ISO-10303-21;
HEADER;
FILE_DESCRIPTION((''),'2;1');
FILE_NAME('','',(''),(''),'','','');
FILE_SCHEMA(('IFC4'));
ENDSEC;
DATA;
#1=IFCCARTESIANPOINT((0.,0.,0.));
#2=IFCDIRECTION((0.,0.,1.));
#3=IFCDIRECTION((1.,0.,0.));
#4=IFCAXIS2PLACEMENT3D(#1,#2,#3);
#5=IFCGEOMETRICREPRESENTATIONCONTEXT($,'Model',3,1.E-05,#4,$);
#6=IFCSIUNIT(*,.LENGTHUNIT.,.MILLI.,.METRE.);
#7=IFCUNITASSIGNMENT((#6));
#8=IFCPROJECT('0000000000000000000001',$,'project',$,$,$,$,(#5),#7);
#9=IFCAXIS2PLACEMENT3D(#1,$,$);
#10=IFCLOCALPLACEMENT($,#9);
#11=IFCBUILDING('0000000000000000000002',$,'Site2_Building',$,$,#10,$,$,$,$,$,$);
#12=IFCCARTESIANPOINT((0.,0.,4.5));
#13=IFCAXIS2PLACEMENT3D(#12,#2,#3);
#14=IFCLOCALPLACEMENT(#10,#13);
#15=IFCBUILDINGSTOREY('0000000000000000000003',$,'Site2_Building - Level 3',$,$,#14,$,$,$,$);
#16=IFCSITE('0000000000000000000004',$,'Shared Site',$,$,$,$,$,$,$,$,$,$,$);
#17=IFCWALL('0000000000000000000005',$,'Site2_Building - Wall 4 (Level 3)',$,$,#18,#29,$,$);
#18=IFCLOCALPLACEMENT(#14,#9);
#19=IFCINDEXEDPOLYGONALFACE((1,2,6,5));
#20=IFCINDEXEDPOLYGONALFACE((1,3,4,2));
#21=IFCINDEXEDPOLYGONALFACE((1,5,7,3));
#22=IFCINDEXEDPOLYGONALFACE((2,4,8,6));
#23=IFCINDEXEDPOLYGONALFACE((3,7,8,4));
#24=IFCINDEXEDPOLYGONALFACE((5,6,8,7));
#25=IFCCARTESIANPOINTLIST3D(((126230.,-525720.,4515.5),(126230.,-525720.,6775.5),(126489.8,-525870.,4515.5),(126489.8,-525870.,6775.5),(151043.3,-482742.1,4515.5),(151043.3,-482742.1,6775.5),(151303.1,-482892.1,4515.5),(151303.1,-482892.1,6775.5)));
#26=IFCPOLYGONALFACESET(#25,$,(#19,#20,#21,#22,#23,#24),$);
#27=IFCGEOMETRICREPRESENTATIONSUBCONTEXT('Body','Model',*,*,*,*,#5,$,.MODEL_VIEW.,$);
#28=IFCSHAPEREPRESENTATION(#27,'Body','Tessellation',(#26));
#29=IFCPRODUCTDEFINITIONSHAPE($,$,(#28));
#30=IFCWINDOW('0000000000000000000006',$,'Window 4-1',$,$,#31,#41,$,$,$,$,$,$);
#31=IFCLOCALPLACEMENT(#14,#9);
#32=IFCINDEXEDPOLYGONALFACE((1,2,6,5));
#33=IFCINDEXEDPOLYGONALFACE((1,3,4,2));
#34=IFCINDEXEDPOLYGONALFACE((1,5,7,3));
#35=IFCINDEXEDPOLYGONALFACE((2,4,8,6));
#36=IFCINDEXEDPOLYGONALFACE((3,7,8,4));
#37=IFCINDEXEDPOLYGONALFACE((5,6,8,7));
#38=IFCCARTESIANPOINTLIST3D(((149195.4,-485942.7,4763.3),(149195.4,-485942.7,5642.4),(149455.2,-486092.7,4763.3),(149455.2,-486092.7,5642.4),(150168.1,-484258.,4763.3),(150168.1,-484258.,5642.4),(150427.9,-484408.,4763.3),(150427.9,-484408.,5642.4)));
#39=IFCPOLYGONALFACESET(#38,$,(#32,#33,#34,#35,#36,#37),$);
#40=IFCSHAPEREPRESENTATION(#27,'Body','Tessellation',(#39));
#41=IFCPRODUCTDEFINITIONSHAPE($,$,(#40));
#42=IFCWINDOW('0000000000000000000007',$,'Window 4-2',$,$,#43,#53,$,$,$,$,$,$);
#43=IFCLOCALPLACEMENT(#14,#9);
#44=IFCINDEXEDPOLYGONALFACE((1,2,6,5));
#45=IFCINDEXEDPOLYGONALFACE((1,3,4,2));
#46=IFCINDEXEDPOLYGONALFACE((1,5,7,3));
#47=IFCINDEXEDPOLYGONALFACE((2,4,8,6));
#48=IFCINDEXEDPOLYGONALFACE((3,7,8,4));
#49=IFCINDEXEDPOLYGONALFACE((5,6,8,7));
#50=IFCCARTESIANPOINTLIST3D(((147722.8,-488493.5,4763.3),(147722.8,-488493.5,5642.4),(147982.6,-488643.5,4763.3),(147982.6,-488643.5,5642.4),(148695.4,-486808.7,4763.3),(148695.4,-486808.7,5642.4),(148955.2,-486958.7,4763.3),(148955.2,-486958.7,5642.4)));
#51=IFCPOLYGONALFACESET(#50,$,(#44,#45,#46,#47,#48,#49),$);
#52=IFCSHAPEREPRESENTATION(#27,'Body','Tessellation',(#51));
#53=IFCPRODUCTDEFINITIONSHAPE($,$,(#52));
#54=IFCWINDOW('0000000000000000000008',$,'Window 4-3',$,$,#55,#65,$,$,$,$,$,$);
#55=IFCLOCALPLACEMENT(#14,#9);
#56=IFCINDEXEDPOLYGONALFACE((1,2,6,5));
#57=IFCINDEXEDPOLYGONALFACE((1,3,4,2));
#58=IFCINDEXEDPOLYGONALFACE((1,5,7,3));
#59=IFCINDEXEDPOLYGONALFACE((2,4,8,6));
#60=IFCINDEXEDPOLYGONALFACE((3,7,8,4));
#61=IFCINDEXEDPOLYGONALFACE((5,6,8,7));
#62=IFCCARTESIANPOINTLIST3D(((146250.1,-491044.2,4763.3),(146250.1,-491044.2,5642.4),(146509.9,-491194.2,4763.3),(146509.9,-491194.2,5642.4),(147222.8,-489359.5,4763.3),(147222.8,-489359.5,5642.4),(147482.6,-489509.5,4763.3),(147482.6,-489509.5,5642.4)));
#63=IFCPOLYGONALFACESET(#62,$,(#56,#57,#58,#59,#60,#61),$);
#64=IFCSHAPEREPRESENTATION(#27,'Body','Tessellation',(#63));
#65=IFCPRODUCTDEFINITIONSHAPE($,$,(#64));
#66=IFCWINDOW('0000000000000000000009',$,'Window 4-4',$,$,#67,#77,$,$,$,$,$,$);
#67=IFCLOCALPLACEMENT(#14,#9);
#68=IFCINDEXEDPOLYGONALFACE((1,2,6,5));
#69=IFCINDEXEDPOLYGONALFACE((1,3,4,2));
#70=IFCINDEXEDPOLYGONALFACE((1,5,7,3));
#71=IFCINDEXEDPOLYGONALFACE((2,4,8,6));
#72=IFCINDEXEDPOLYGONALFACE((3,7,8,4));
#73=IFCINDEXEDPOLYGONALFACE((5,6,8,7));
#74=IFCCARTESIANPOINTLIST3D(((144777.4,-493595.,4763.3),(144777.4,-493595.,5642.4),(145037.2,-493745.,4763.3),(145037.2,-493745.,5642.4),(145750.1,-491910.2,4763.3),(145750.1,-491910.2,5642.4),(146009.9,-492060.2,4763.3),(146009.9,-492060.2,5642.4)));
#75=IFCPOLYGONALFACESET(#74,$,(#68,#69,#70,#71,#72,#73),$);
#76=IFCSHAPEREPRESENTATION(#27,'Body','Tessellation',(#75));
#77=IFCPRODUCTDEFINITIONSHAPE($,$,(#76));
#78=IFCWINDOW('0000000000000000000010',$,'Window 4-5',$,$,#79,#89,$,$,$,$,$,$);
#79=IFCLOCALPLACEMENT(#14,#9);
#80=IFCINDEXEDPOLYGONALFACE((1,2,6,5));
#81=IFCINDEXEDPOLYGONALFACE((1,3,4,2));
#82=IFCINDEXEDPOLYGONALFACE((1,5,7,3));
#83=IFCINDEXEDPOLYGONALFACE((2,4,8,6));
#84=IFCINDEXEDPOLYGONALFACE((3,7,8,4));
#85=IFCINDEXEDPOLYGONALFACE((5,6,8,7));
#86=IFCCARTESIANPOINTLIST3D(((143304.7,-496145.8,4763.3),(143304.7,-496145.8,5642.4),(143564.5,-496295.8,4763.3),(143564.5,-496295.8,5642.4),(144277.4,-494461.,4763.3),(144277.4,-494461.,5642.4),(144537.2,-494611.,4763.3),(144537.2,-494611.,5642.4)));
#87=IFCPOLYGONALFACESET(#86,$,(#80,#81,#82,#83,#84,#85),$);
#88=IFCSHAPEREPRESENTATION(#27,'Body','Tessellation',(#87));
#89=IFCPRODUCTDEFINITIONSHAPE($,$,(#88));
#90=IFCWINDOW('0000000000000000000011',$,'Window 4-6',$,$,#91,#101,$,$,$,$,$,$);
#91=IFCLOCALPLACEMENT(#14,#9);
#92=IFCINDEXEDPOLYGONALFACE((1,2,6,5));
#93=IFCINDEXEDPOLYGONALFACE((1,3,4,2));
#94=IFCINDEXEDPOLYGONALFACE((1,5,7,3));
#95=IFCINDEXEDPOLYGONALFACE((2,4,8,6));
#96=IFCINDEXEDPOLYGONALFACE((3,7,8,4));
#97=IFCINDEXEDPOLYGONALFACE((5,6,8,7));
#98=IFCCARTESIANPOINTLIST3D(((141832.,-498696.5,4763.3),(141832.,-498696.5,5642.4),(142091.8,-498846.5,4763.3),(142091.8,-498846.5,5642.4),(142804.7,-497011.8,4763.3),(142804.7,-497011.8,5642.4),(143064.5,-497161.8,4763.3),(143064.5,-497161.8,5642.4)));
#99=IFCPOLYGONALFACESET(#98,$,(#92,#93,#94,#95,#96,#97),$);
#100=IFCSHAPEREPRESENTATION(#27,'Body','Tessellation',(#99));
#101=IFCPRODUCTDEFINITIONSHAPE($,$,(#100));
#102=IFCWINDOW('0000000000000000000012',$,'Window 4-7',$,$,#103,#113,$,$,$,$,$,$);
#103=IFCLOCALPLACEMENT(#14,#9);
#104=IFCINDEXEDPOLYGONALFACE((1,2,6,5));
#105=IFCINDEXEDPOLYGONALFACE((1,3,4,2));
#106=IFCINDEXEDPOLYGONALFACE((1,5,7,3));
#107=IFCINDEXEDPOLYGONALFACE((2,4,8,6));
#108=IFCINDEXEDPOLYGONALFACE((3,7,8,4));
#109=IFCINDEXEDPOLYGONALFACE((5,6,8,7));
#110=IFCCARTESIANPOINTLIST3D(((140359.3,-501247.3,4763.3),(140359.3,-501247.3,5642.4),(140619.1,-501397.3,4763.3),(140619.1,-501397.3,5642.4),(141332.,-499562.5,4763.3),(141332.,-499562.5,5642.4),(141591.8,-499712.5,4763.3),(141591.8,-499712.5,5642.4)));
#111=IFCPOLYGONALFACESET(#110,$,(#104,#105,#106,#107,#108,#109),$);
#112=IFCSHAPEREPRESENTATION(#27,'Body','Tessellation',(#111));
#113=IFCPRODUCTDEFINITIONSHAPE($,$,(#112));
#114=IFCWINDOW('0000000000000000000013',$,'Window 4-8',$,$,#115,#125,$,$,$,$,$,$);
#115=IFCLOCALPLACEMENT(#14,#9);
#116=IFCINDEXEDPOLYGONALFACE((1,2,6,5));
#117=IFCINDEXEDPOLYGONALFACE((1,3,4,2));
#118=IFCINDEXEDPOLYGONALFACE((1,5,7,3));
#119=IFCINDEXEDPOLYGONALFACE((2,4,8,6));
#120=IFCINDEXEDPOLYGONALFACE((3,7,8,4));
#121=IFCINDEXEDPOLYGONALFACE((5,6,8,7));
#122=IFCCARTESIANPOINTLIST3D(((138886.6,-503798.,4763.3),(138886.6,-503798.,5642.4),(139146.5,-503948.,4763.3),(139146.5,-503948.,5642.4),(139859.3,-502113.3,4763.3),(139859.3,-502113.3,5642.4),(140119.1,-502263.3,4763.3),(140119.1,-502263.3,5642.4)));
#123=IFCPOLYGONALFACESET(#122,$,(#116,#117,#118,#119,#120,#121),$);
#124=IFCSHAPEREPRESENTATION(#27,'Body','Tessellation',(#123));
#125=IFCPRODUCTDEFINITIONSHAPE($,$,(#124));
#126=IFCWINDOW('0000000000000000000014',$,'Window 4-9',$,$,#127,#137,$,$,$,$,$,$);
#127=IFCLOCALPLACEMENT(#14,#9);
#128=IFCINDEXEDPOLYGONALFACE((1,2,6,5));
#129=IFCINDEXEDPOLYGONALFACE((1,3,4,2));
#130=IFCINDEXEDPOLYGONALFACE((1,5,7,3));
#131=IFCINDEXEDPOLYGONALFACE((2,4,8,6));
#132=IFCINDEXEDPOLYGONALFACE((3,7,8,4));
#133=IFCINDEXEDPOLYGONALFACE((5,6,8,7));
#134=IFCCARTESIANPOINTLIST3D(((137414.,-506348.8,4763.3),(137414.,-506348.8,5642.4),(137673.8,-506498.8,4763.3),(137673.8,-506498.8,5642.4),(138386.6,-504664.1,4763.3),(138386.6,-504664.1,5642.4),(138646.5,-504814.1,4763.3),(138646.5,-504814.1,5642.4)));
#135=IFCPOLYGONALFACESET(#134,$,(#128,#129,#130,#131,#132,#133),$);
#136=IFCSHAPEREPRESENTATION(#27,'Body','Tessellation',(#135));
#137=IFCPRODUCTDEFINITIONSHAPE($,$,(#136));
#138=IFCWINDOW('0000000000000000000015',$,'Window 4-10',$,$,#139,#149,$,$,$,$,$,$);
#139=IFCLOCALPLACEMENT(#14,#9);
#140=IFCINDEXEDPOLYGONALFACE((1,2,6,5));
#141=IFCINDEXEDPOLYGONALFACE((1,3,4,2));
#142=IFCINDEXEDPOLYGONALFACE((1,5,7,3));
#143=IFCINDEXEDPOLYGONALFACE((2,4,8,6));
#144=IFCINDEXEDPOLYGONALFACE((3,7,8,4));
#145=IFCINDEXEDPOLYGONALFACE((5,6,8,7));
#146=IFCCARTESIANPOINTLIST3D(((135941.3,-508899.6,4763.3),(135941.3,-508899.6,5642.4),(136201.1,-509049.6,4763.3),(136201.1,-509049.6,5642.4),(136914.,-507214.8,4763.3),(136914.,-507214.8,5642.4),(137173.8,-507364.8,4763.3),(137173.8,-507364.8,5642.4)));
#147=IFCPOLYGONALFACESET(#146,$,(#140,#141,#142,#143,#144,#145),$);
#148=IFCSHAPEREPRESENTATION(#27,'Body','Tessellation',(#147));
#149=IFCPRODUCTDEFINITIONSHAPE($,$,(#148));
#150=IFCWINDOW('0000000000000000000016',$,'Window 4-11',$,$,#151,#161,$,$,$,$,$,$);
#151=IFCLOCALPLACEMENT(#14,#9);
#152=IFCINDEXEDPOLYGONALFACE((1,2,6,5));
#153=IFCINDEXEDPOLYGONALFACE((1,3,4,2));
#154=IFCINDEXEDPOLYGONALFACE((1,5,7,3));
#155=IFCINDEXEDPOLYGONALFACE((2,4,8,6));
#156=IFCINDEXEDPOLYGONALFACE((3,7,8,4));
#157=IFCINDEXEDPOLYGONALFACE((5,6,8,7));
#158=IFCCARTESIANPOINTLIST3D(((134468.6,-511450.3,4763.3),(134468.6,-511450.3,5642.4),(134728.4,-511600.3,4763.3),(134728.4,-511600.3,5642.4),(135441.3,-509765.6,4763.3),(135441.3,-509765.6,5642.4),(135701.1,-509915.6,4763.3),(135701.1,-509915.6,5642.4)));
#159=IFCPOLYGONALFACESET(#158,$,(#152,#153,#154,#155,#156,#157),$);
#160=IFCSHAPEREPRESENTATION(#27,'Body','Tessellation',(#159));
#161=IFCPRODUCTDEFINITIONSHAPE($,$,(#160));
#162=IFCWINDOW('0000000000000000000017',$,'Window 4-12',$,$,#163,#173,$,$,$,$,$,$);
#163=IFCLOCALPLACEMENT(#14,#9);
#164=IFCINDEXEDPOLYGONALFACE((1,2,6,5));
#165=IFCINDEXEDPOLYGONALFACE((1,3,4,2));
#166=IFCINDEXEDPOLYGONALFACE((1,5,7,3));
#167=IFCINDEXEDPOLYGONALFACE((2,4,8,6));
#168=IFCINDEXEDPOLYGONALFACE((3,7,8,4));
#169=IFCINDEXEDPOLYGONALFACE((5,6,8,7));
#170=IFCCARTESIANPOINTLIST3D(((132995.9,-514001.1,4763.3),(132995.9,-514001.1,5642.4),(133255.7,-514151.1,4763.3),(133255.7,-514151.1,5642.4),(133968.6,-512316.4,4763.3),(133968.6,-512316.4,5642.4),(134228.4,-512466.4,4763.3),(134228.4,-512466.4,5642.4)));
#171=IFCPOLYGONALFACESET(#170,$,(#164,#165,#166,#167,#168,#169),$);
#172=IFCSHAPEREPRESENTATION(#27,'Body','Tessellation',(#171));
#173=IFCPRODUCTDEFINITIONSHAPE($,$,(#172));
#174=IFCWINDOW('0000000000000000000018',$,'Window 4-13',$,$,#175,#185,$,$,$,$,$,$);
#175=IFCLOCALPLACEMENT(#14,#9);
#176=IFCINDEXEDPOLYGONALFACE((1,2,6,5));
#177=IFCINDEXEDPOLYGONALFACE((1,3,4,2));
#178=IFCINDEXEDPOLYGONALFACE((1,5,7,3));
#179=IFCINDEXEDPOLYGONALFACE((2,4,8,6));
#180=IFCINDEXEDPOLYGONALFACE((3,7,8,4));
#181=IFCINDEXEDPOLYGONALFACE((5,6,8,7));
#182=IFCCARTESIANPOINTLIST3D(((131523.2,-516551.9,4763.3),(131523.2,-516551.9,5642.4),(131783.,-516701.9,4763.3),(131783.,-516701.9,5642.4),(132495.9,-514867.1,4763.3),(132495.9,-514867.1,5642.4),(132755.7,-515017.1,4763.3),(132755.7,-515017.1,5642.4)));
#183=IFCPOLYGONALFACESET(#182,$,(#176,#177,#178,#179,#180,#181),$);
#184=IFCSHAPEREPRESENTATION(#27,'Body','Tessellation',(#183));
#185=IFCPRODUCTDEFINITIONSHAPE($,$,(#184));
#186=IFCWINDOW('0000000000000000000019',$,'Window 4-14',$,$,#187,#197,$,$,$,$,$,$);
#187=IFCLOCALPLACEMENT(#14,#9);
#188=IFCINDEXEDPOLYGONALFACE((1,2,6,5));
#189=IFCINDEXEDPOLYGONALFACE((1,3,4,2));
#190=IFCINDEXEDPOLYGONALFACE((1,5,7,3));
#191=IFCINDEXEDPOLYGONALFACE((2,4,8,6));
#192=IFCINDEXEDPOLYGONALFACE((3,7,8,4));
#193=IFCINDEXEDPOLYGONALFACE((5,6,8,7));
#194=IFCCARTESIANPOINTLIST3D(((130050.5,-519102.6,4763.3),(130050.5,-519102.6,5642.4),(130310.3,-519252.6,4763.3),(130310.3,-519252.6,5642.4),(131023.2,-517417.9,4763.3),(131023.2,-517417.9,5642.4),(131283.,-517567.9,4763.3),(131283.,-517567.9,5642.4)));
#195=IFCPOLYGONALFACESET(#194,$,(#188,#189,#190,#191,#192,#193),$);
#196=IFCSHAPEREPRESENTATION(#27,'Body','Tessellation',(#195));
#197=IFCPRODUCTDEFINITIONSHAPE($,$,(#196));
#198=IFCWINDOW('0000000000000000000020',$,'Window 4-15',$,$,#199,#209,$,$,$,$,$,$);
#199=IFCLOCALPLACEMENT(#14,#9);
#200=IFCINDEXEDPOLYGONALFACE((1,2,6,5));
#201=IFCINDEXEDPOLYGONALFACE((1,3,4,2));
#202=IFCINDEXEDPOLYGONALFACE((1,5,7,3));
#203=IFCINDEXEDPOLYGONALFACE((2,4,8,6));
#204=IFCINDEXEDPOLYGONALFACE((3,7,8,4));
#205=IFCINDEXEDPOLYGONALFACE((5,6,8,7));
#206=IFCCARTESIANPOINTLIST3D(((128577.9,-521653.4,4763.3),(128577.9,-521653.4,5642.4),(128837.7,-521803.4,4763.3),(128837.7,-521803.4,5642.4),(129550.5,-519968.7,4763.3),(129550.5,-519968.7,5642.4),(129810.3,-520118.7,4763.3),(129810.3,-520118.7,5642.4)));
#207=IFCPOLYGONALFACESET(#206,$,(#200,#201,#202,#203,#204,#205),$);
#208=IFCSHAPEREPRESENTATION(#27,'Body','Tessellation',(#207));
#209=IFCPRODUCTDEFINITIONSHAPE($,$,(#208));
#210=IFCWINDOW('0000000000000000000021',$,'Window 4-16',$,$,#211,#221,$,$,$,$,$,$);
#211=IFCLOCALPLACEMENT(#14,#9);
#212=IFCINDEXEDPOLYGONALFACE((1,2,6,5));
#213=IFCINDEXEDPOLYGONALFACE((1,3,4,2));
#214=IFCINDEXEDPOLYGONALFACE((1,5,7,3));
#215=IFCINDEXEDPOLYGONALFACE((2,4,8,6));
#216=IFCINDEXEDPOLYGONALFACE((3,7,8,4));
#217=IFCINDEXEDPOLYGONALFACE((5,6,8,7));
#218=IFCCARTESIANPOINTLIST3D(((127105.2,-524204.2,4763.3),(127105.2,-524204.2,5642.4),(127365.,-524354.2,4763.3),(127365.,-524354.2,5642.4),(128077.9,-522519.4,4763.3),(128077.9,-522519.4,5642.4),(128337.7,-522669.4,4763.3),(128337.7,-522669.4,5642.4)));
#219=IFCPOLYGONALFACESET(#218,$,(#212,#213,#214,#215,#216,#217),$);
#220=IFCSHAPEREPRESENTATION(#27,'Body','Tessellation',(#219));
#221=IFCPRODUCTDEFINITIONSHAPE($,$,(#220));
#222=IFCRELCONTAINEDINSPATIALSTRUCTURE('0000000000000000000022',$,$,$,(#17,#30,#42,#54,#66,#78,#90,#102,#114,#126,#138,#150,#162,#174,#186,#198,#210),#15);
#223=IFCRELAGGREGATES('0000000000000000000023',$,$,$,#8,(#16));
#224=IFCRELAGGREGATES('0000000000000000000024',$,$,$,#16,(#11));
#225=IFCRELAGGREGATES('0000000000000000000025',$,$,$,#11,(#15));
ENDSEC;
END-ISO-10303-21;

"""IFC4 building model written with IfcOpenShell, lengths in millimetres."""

from ifc_helpers import new_model, si_unit, frame, origin, origin_with_axes, place, context, subcontext, project, spatial, indexed_curve, outline, extrude, element, save


model = new_model("IFC4")

# Units and contexts
model_context = context("Model", 3, precision=1e-05, world=origin_with_axes())
body_context = subcontext(model_context, "Body", "Model", "MODEL_VIEW")
ifc_project = project(units=[si_unit("LENGTHUNIT", "METRE", prefix="MILLI")], contexts=[model_context])

# Site, building, storey
site = spatial("IfcSite", under=ifc_project, Name="Shared Site")
building_placement = place(None, origin())
building = spatial("IfcBuilding", under=site, at=building_placement, Name="Site2_Building")
storey_placement = place(building_placement, frame((0.0, 0.0, 4.5), z_axis=(0.0, 0.0, 1.0), x_axis=(1.0, 0.0, 0.0)))
storey = spatial("IfcBuildingStorey", under=building, at=storey_placement, Name="Site2_Building - Level 3")

# Wall
wall_1_placement = place(storey_placement, frame((151043.3, -482742.1, 4515.5), z_axis=(0.0, 0.0, 1.0), x_axis=(-0.5, -0.866025, 0.0)))
element("IfcWall", 1, at=wall_1_placement, inside=storey, Name="Site2_Building - Wall 4 (Level 3)", context=body_context, shape_type="SweptSolid", body=[
    extrude(outline(indexed_curve([(0.0, 0.0), (0.0, 300.0), (49626.6, 300.0), (49626.6, 0.0), (0.0, 0.0)], self_intersect=False)), origin_with_axes(), (0.0, 0.0, 1.0), 2260.0),
])

# Windows
for number, where, z_axis, x_axis, name in (
    (2, (150168.1, -484258.0, 4763.3), (0.0, 0.0, 1.0), (-0.5, -0.866025, 0.0), "Window 4-1"),
    (3, (148695.4, -486808.7, 4763.3), (0.0, 0.0, 1.0), (-0.5, -0.866025, 0.0), "Window 4-2"),
    (4, (147222.8, -489359.5, 4763.3), (0.0, 0.0, 1.0), (-0.5, -0.866025, 0.0), "Window 4-3"),
    (5, (145750.1, -491910.2, 4763.3), (0.0, 0.0, 1.0), (-0.5, -0.866025, 0.0), "Window 4-4"),
    (6, (144277.4, -494461.0, 4763.3), (0.0, 0.0, 1.0), (-0.5, -0.866025, 0.0), "Window 4-5"),
    (7, (142804.7, -497011.8, 4763.3), (0.0, 0.0, 1.0), (-0.5, -0.866025, 0.0), "Window 4-6"),
    (8, (141332.0, -499562.5, 4763.3), (0.0, 0.0, 1.0), (-0.5, -0.866025, 0.0), "Window 4-7"),
    (9, (139859.3, -502113.3, 4763.3), (0.0, 0.0, 1.0), (-0.5, -0.866025, 0.0), "Window 4-8"),
    (10, (138386.6, -504664.1, 4763.3), (0.0, 0.0, 1.0), (-0.5, -0.866025, 0.0), "Window 4-9"),
    (11, (136914.0, -507214.8, 4763.3), (0.0, 0.0, 1.0), (-0.5, -0.866025, 0.0), "Window 4-10"),
    (12, (135441.3, -509765.6, 4763.3), (0.0, 0.0, 1.0), (-0.5, -0.866025, 0.0), "Window 4-11"),
    (13, (133968.6, -512316.4, 4763.3), (0.0, 0.0, 1.0), (-0.5, -0.866025, 0.0), "Window 4-12"),
    (14, (132495.9, -514867.1, 4763.3), (0.0, 0.0, 1.0), (-0.5, -0.866025, 0.0), "Window 4-13"),
    (15, (131023.2, -517417.9, 4763.3), (0.0, 0.0, 1.0), (-0.5, -0.866025, 0.0), "Window 4-14"),
    (16, (129550.5, -519968.7, 4763.3), (0.0, 0.0, 1.0), (-0.5, -0.866025, 0.0), "Window 4-15"),
    (17, (128077.9, -522519.4, 4763.3), (0.0, 0.0, 1.0), (-0.5, -0.866025, 0.0), "Window 4-16"),
):
    element("IfcWindow", number, at=place(storey_placement, frame(where, z_axis=z_axis, x_axis=x_axis)), inside=storey, Name=name, context=body_context, shape_type="SweptSolid", body=[
        extrude(outline(indexed_curve([(0.0, 0.0), (0.0, 300.0), (1945.4, 300.0), (1945.4, 0.0), (0.0, 0.0)], self_intersect=False)), origin_with_axes(), (0.0, 0.0, 1.0), 879.1),
    ])

save(model, "model.ifc")
